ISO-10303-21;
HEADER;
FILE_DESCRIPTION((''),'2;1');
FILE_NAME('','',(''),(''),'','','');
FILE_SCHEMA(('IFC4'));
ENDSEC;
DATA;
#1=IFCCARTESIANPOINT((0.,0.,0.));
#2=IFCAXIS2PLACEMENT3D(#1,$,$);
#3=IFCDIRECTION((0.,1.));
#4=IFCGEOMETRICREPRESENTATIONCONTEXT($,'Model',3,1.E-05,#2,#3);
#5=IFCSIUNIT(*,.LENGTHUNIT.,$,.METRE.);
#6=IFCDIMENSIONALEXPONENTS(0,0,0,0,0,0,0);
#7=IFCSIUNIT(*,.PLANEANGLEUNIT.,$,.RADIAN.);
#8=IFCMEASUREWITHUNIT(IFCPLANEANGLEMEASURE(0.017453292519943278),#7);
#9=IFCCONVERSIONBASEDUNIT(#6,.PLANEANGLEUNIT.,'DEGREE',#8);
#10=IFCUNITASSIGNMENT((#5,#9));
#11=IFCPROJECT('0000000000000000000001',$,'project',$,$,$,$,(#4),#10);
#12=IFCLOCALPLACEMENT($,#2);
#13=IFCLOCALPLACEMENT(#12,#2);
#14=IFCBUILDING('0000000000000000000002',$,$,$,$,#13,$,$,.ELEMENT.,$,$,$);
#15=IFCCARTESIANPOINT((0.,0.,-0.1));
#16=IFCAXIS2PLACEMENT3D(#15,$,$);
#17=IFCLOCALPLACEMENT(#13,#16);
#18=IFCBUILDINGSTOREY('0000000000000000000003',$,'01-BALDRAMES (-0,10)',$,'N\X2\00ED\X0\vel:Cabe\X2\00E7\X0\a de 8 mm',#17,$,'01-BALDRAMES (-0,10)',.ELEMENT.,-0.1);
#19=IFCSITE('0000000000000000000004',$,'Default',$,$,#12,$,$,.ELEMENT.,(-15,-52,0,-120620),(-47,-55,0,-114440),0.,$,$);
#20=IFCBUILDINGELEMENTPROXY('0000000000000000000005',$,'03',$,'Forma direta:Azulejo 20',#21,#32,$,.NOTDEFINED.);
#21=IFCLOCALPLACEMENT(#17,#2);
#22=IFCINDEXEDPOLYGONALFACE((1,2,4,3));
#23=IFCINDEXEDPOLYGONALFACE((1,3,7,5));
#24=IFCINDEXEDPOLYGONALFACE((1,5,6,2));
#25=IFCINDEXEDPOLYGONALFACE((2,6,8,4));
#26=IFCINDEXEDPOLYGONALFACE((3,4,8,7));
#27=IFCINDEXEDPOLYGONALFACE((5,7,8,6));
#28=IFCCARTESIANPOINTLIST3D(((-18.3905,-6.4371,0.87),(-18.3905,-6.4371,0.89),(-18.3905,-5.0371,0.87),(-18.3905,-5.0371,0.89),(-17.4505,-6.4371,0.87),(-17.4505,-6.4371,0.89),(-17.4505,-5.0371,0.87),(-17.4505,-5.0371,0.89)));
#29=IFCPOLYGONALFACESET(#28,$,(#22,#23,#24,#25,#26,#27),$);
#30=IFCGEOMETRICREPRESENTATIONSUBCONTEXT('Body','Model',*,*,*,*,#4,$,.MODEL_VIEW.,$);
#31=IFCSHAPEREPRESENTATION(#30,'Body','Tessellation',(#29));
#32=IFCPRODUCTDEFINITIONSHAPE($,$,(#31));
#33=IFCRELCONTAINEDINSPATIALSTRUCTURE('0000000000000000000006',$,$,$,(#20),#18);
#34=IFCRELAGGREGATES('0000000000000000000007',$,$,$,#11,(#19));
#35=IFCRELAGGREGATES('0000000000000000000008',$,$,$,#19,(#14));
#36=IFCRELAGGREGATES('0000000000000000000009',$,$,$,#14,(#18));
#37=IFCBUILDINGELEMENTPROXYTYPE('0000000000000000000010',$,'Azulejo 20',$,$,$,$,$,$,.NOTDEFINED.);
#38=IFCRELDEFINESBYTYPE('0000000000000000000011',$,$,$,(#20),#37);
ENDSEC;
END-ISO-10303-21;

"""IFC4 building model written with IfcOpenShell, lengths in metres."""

from ifc_helpers import new_model, entity, si_unit, converted_unit, direction, frame, origin, place, context, subcontext, project, spatial, indexed_curve, outline, extrude, type_object, element, save


model = new_model("IFC4")

# Units and contexts
model_context = context("Model", 3, precision=1e-05, world=origin(), true_north=direction((0.0, 1.0)))
body_context = subcontext(model_context, "Body", "Model", "MODEL_VIEW")
ifc_project = project(units=[si_unit("LENGTHUNIT", "METRE"), converted_unit("PLANEANGLEUNIT", "DEGREE", entity("IfcPlaneAngleMeasure", 0.017453292519943278), si_unit("PLANEANGLEUNIT", "RADIAN"), dimensions=[0, 0, 0, 0, 0, 0, 0])], contexts=[model_context])

# Site, building, storey
site_placement = place(None, origin())
site = spatial("IfcSite", under=ifc_project, at=site_placement, Name="Default", CompositionType="ELEMENT", RefLatitude=(-15, -52, 0, -120620), RefLongitude=(-47, -55, 0, -114440), RefElevation=0.0)
building_placement = place(site_placement, origin())
building = spatial("IfcBuilding", under=site, at=building_placement, CompositionType="ELEMENT")
storey_placement = place(building_placement, frame((0.0, 0.0, -0.1)))
storey = spatial("IfcBuildingStorey", under=building, at=storey_placement, Name="01-BALDRAMES (-0,10)", ObjectType="Nível:Cabeça de 8 mm", LongName="01-BALDRAMES (-0,10)", CompositionType="ELEMENT", Elevation=-0.1)

# Building element proxy
building_element_proxy_type_1 = type_object("IfcBuildingElementProxyType", Name="Azulejo 20", PredefinedType="NOTDEFINED")
proxy_1_placement = place(storey_placement, origin())
element("IfcBuildingElementProxy", 1, at=proxy_1_placement, inside=storey, type_object=building_element_proxy_type_1, Name="03", ObjectType="Forma direta:Azulejo 20", PredefinedType="NOTDEFINED", context=body_context, shape_type="SweptSolid", body=[
    extrude(outline(indexed_curve([(-0.47, -0.7), (0.47, -0.7), (0.47, 0.7), (-0.47, 0.7), (-0.47, -0.7)], self_intersect=False)), frame((-17.9205, -5.7371, 0.87)), (0.0, 0.0, 1.0), 0.02),
])

save(model, "model.ifc")
